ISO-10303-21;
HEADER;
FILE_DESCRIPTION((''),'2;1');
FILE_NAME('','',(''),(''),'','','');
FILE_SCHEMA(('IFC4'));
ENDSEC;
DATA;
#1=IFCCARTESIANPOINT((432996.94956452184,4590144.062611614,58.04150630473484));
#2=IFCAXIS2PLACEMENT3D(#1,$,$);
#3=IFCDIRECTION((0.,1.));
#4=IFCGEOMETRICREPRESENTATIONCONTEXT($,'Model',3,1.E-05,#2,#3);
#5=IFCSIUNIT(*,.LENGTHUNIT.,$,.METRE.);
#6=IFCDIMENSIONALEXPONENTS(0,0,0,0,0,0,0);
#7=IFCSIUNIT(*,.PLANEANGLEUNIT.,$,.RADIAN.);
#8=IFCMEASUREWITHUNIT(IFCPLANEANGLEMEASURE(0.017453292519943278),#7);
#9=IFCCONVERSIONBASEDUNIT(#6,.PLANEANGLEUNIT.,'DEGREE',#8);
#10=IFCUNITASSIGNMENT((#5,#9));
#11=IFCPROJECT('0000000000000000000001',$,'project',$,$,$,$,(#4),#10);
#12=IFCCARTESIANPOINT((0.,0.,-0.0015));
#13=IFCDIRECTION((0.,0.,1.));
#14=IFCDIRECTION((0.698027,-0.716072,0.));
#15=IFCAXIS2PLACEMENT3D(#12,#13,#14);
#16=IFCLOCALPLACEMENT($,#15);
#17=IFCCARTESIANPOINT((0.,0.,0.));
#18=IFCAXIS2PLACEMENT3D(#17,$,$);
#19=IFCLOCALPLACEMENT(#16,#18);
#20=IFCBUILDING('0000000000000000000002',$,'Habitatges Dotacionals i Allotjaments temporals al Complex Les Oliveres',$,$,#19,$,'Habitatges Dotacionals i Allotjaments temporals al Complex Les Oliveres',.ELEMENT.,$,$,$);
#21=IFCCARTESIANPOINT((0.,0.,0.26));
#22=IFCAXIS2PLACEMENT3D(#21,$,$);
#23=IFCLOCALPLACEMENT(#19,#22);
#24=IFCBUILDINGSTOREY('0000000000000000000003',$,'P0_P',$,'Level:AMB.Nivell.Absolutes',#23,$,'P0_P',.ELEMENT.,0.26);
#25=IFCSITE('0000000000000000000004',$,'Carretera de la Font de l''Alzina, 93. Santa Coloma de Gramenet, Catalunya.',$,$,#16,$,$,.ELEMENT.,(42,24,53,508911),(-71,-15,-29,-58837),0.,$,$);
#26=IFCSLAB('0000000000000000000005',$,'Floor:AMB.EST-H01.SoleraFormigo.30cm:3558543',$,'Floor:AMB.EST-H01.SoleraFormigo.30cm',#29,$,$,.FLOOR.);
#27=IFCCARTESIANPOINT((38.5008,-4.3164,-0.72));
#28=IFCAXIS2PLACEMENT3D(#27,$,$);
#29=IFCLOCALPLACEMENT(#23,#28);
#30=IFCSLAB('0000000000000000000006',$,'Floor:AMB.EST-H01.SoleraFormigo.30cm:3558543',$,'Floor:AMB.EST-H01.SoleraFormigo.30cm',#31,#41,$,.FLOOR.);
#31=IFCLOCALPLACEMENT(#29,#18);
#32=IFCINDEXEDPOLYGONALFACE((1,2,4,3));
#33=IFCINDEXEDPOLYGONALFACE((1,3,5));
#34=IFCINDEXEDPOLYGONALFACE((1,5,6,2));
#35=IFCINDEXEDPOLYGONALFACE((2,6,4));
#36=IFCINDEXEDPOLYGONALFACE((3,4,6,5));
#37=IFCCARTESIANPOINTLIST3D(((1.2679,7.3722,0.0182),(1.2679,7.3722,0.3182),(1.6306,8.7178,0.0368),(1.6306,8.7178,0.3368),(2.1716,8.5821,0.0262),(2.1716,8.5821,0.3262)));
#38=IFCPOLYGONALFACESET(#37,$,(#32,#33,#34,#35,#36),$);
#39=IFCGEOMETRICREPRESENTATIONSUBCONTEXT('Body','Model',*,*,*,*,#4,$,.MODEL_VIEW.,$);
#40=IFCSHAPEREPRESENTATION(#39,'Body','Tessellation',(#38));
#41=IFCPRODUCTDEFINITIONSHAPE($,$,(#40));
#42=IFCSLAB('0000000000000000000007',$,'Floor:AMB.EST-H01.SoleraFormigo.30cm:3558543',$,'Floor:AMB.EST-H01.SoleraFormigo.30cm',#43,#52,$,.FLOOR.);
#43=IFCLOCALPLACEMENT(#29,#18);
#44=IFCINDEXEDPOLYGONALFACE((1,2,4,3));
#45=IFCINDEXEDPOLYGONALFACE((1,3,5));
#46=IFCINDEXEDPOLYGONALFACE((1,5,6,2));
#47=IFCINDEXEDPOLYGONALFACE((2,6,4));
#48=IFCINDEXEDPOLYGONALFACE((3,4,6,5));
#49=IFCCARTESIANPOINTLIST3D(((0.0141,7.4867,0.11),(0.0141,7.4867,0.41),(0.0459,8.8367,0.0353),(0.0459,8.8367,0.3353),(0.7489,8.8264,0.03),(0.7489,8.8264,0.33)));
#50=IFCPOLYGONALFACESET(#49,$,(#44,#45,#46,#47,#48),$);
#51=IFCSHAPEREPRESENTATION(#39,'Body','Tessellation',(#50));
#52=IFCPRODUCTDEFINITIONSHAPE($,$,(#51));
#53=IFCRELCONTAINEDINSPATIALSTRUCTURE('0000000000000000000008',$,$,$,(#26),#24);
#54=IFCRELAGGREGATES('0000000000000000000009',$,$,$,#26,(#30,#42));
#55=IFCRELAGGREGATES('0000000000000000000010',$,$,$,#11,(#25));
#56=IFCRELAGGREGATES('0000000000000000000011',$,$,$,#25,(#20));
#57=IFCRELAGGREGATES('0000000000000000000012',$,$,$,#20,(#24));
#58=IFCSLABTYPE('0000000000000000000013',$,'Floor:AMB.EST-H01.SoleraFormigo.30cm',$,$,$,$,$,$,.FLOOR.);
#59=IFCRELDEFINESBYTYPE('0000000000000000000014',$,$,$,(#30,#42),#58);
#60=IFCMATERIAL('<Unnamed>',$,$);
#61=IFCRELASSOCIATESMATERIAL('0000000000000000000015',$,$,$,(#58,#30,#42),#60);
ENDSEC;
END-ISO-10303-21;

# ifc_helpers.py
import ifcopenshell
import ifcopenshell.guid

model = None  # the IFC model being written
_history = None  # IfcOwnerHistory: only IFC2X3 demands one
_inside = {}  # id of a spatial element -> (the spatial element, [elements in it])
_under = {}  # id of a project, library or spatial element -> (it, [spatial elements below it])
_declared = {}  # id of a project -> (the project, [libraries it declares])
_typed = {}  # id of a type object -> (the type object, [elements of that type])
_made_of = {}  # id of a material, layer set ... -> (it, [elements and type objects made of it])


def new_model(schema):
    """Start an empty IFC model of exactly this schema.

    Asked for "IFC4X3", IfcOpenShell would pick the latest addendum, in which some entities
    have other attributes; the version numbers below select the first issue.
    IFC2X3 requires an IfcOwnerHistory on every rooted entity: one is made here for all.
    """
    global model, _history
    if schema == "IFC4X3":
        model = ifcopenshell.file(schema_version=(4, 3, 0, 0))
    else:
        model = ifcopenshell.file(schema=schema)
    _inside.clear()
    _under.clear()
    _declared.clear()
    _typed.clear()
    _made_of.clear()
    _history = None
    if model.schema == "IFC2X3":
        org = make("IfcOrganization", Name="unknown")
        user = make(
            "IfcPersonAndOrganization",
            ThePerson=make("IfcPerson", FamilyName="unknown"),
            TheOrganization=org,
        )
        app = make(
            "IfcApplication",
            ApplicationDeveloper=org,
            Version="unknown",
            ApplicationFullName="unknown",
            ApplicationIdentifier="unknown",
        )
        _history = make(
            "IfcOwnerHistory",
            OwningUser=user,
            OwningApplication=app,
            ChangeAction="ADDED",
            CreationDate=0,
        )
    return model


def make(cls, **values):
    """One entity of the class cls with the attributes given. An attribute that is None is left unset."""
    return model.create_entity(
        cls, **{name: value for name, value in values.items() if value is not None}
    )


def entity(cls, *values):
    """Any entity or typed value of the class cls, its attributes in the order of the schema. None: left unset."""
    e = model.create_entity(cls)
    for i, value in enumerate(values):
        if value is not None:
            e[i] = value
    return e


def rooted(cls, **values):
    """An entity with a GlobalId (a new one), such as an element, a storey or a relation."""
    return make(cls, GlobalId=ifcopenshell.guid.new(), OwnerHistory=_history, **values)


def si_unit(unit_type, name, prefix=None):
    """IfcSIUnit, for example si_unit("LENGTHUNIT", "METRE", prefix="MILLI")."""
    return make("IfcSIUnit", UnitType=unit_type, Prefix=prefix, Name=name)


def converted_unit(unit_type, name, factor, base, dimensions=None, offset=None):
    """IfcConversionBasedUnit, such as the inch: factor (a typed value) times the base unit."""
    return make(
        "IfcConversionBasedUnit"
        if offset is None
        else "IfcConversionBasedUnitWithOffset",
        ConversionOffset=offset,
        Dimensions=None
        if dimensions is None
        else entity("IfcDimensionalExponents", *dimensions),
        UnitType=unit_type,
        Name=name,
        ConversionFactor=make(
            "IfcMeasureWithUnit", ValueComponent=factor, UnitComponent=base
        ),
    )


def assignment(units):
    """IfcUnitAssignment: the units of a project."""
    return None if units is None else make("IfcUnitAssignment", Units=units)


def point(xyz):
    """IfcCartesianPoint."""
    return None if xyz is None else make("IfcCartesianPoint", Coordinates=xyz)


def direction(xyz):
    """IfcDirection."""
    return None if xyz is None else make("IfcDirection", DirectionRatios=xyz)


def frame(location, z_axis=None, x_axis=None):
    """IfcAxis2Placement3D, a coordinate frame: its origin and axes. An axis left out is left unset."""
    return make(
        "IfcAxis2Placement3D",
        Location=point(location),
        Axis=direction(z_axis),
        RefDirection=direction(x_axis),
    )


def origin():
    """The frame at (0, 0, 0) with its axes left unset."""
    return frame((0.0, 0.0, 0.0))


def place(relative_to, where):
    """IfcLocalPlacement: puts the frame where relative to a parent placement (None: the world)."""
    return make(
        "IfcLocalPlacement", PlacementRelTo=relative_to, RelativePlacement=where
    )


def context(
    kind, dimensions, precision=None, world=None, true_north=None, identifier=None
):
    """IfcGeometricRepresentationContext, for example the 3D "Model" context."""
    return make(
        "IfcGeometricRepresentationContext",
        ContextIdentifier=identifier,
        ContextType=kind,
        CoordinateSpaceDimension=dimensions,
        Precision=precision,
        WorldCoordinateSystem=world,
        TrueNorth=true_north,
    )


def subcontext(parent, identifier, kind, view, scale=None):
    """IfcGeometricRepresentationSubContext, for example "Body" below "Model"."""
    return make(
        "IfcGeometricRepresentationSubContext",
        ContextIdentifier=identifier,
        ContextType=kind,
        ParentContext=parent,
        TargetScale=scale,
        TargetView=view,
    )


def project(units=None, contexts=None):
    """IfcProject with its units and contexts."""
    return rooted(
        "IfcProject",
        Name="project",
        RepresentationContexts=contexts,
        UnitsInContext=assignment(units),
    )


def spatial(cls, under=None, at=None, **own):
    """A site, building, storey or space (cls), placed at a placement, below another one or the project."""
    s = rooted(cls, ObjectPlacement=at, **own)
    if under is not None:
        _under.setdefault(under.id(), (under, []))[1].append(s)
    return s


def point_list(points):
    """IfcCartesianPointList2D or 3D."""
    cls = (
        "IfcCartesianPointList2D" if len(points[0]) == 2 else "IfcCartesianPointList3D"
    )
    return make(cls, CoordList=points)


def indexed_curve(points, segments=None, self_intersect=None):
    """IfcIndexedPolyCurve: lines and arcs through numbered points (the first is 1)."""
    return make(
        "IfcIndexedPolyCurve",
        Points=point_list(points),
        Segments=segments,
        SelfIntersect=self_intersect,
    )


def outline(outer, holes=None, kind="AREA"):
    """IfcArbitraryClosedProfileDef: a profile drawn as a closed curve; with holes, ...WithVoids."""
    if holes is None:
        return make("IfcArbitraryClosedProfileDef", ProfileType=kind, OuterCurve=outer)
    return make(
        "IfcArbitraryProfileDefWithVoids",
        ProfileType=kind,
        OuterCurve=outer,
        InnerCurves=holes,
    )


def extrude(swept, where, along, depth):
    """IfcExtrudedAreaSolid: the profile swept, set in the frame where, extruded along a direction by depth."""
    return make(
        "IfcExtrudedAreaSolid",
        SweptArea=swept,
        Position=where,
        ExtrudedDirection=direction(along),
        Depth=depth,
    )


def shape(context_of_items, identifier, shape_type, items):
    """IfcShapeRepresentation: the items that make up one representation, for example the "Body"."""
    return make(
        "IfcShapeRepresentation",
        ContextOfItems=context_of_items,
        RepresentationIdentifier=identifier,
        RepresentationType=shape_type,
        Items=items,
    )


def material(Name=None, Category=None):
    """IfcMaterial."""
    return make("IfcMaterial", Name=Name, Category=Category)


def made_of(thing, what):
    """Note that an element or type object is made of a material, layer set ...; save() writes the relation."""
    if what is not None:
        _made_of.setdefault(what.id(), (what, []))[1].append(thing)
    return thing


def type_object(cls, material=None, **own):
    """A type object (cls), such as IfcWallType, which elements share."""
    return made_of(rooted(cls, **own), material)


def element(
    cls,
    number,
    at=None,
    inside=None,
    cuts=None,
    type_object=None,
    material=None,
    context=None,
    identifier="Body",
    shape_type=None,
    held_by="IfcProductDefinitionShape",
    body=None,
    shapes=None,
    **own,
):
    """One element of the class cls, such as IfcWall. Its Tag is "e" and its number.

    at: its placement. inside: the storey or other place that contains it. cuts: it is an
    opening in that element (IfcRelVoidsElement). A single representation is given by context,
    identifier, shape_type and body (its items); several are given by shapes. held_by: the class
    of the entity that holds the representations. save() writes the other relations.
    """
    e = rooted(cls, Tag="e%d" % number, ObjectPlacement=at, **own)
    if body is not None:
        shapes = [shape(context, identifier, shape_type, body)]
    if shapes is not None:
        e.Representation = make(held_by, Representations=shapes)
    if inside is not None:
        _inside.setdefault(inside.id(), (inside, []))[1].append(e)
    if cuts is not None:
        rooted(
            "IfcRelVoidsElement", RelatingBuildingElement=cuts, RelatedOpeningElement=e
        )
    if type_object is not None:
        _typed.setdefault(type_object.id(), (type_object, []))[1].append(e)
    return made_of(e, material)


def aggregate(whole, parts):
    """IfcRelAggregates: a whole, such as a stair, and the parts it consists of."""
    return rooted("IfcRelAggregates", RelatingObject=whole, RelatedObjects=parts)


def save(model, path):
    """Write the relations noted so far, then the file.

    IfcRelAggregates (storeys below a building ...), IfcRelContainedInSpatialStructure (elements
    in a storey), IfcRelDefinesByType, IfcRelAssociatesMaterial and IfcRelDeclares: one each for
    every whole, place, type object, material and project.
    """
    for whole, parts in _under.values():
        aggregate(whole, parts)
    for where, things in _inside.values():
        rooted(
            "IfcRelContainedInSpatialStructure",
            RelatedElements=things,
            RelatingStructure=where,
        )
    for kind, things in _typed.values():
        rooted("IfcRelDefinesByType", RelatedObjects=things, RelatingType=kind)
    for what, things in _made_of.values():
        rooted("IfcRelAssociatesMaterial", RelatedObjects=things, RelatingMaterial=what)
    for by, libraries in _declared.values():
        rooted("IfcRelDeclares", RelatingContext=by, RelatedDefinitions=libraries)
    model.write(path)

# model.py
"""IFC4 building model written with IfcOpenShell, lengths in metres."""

from ifc_helpers import new_model, entity, si_unit, converted_unit, direction, frame, origin, place, context, subcontext, project, spatial, indexed_curve, outline, extrude, material, type_object, element, aggregate, save


model = new_model("IFC4")

# Units and contexts
model_context = context("Model", 3, precision=1e-05, world=frame((432996.94956452184, 4590144.062611614, 58.04150630473484)), true_north=direction((0.0, 1.0)))
body_context = subcontext(model_context, "Body", "Model", "MODEL_VIEW")
ifc_project = project(units=[si_unit("LENGTHUNIT", "METRE"), converted_unit("PLANEANGLEUNIT", "DEGREE", entity("IfcPlaneAngleMeasure", 0.017453292519943278), si_unit("PLANEANGLEUNIT", "RADIAN"), dimensions=[0, 0, 0, 0, 0, 0, 0])], contexts=[model_context])

# Site, building, storey
site_placement = place(None, frame((0.0, 0.0, -0.0015), z_axis=(0.0, 0.0, 1.0), x_axis=(0.698027, -0.716072, 0.0)))
site = spatial("IfcSite", under=ifc_project, at=site_placement, Name="Carretera de la Font de l'Alzina, 93. Santa Coloma de Gramenet, Catalunya.", CompositionType="ELEMENT", RefLatitude=(42, 24, 53, 508911), RefLongitude=(-71, -15, -29, -58837), RefElevation=0.0)
building_placement = place(site_placement, origin())
building = spatial("IfcBuilding", under=site, at=building_placement, Name="Habitatges Dotacionals i Allotjaments temporals al Complex Les Oliveres", LongName="Habitatges Dotacionals i Allotjaments temporals al Complex Les Oliveres", CompositionType="ELEMENT")
storey_placement = place(building_placement, frame((0.0, 0.0, 0.26)))
storey = spatial("IfcBuildingStorey", under=building, at=storey_placement, Name="P0_P", ObjectType="Level:AMB.Nivell.Absolutes", LongName="P0_P", CompositionType="ELEMENT", Elevation=0.26)

# Slabs
slab_1_placement = place(storey_placement, frame((38.5008, -4.3164, -0.72)))
slab_1 = element("IfcSlab", 1, at=slab_1_placement, inside=storey, Name="Floor:AMB.EST-H01.SoleraFormigo.30cm:3558543", ObjectType="Floor:AMB.EST-H01.SoleraFormigo.30cm", PredefinedType="FLOOR")
ifc_material_1 = material(Name="<Unnamed>")
slab_type = type_object("IfcSlabType", Name="Floor:AMB.EST-H01.SoleraFormigo.30cm", PredefinedType="FLOOR", material=ifc_material_1)
slab_2_placement = place(slab_1_placement, origin())
slab_2 = element("IfcSlab", 2, at=slab_2_placement, type_object=slab_type, material=ifc_material_1, Name="Floor:AMB.EST-H01.SoleraFormigo.30cm:3558543", ObjectType="Floor:AMB.EST-H01.SoleraFormigo.30cm", PredefinedType="FLOOR", context=body_context, shape_type="SweptSolid", body=[
    extrude(outline(indexed_curve([(0.4519, 0.6049), (-0.0891, 0.7408), (-0.4519, -0.6049), (0.4519, 0.6049)], self_intersect=False)), frame((1.7197, 7.9772, 0.3222), z_axis=(0.01507, -0.017851, 0.999727), x_axis=(0.999886, 0.000269, -0.015068)), (0.015068, -0.017853, -0.999727), 0.3),
])
slab_3_placement = place(slab_1_placement, origin())
slab_3 = element("IfcSlab", 3, at=slab_3_placement, type_object=slab_type, material=ifc_material_1, Name="Floor:AMB.EST-H01.SoleraFormigo.30cm:3558543", ObjectType="Floor:AMB.EST-H01.SoleraFormigo.30cm", PredefinedType="FLOOR", context=body_context, shape_type="SweptSolid", body=[
    extrude(outline(indexed_curve([(0.3674, 0.671), (-0.3356, 0.6811), (-0.3674, -0.671), (0.3674, 0.671)], self_intersect=False)), frame((0.3815, 8.1565, 0.37), z_axis=(0.008262, 0.055111, 0.998446), x_axis=(0.999966, -0.000455, -0.00825)), (0.00825, 0.055112, -0.998446), 0.3),
])
aggregate(slab_1, [slab_2, slab_3])

save(model, "model.ifc")
